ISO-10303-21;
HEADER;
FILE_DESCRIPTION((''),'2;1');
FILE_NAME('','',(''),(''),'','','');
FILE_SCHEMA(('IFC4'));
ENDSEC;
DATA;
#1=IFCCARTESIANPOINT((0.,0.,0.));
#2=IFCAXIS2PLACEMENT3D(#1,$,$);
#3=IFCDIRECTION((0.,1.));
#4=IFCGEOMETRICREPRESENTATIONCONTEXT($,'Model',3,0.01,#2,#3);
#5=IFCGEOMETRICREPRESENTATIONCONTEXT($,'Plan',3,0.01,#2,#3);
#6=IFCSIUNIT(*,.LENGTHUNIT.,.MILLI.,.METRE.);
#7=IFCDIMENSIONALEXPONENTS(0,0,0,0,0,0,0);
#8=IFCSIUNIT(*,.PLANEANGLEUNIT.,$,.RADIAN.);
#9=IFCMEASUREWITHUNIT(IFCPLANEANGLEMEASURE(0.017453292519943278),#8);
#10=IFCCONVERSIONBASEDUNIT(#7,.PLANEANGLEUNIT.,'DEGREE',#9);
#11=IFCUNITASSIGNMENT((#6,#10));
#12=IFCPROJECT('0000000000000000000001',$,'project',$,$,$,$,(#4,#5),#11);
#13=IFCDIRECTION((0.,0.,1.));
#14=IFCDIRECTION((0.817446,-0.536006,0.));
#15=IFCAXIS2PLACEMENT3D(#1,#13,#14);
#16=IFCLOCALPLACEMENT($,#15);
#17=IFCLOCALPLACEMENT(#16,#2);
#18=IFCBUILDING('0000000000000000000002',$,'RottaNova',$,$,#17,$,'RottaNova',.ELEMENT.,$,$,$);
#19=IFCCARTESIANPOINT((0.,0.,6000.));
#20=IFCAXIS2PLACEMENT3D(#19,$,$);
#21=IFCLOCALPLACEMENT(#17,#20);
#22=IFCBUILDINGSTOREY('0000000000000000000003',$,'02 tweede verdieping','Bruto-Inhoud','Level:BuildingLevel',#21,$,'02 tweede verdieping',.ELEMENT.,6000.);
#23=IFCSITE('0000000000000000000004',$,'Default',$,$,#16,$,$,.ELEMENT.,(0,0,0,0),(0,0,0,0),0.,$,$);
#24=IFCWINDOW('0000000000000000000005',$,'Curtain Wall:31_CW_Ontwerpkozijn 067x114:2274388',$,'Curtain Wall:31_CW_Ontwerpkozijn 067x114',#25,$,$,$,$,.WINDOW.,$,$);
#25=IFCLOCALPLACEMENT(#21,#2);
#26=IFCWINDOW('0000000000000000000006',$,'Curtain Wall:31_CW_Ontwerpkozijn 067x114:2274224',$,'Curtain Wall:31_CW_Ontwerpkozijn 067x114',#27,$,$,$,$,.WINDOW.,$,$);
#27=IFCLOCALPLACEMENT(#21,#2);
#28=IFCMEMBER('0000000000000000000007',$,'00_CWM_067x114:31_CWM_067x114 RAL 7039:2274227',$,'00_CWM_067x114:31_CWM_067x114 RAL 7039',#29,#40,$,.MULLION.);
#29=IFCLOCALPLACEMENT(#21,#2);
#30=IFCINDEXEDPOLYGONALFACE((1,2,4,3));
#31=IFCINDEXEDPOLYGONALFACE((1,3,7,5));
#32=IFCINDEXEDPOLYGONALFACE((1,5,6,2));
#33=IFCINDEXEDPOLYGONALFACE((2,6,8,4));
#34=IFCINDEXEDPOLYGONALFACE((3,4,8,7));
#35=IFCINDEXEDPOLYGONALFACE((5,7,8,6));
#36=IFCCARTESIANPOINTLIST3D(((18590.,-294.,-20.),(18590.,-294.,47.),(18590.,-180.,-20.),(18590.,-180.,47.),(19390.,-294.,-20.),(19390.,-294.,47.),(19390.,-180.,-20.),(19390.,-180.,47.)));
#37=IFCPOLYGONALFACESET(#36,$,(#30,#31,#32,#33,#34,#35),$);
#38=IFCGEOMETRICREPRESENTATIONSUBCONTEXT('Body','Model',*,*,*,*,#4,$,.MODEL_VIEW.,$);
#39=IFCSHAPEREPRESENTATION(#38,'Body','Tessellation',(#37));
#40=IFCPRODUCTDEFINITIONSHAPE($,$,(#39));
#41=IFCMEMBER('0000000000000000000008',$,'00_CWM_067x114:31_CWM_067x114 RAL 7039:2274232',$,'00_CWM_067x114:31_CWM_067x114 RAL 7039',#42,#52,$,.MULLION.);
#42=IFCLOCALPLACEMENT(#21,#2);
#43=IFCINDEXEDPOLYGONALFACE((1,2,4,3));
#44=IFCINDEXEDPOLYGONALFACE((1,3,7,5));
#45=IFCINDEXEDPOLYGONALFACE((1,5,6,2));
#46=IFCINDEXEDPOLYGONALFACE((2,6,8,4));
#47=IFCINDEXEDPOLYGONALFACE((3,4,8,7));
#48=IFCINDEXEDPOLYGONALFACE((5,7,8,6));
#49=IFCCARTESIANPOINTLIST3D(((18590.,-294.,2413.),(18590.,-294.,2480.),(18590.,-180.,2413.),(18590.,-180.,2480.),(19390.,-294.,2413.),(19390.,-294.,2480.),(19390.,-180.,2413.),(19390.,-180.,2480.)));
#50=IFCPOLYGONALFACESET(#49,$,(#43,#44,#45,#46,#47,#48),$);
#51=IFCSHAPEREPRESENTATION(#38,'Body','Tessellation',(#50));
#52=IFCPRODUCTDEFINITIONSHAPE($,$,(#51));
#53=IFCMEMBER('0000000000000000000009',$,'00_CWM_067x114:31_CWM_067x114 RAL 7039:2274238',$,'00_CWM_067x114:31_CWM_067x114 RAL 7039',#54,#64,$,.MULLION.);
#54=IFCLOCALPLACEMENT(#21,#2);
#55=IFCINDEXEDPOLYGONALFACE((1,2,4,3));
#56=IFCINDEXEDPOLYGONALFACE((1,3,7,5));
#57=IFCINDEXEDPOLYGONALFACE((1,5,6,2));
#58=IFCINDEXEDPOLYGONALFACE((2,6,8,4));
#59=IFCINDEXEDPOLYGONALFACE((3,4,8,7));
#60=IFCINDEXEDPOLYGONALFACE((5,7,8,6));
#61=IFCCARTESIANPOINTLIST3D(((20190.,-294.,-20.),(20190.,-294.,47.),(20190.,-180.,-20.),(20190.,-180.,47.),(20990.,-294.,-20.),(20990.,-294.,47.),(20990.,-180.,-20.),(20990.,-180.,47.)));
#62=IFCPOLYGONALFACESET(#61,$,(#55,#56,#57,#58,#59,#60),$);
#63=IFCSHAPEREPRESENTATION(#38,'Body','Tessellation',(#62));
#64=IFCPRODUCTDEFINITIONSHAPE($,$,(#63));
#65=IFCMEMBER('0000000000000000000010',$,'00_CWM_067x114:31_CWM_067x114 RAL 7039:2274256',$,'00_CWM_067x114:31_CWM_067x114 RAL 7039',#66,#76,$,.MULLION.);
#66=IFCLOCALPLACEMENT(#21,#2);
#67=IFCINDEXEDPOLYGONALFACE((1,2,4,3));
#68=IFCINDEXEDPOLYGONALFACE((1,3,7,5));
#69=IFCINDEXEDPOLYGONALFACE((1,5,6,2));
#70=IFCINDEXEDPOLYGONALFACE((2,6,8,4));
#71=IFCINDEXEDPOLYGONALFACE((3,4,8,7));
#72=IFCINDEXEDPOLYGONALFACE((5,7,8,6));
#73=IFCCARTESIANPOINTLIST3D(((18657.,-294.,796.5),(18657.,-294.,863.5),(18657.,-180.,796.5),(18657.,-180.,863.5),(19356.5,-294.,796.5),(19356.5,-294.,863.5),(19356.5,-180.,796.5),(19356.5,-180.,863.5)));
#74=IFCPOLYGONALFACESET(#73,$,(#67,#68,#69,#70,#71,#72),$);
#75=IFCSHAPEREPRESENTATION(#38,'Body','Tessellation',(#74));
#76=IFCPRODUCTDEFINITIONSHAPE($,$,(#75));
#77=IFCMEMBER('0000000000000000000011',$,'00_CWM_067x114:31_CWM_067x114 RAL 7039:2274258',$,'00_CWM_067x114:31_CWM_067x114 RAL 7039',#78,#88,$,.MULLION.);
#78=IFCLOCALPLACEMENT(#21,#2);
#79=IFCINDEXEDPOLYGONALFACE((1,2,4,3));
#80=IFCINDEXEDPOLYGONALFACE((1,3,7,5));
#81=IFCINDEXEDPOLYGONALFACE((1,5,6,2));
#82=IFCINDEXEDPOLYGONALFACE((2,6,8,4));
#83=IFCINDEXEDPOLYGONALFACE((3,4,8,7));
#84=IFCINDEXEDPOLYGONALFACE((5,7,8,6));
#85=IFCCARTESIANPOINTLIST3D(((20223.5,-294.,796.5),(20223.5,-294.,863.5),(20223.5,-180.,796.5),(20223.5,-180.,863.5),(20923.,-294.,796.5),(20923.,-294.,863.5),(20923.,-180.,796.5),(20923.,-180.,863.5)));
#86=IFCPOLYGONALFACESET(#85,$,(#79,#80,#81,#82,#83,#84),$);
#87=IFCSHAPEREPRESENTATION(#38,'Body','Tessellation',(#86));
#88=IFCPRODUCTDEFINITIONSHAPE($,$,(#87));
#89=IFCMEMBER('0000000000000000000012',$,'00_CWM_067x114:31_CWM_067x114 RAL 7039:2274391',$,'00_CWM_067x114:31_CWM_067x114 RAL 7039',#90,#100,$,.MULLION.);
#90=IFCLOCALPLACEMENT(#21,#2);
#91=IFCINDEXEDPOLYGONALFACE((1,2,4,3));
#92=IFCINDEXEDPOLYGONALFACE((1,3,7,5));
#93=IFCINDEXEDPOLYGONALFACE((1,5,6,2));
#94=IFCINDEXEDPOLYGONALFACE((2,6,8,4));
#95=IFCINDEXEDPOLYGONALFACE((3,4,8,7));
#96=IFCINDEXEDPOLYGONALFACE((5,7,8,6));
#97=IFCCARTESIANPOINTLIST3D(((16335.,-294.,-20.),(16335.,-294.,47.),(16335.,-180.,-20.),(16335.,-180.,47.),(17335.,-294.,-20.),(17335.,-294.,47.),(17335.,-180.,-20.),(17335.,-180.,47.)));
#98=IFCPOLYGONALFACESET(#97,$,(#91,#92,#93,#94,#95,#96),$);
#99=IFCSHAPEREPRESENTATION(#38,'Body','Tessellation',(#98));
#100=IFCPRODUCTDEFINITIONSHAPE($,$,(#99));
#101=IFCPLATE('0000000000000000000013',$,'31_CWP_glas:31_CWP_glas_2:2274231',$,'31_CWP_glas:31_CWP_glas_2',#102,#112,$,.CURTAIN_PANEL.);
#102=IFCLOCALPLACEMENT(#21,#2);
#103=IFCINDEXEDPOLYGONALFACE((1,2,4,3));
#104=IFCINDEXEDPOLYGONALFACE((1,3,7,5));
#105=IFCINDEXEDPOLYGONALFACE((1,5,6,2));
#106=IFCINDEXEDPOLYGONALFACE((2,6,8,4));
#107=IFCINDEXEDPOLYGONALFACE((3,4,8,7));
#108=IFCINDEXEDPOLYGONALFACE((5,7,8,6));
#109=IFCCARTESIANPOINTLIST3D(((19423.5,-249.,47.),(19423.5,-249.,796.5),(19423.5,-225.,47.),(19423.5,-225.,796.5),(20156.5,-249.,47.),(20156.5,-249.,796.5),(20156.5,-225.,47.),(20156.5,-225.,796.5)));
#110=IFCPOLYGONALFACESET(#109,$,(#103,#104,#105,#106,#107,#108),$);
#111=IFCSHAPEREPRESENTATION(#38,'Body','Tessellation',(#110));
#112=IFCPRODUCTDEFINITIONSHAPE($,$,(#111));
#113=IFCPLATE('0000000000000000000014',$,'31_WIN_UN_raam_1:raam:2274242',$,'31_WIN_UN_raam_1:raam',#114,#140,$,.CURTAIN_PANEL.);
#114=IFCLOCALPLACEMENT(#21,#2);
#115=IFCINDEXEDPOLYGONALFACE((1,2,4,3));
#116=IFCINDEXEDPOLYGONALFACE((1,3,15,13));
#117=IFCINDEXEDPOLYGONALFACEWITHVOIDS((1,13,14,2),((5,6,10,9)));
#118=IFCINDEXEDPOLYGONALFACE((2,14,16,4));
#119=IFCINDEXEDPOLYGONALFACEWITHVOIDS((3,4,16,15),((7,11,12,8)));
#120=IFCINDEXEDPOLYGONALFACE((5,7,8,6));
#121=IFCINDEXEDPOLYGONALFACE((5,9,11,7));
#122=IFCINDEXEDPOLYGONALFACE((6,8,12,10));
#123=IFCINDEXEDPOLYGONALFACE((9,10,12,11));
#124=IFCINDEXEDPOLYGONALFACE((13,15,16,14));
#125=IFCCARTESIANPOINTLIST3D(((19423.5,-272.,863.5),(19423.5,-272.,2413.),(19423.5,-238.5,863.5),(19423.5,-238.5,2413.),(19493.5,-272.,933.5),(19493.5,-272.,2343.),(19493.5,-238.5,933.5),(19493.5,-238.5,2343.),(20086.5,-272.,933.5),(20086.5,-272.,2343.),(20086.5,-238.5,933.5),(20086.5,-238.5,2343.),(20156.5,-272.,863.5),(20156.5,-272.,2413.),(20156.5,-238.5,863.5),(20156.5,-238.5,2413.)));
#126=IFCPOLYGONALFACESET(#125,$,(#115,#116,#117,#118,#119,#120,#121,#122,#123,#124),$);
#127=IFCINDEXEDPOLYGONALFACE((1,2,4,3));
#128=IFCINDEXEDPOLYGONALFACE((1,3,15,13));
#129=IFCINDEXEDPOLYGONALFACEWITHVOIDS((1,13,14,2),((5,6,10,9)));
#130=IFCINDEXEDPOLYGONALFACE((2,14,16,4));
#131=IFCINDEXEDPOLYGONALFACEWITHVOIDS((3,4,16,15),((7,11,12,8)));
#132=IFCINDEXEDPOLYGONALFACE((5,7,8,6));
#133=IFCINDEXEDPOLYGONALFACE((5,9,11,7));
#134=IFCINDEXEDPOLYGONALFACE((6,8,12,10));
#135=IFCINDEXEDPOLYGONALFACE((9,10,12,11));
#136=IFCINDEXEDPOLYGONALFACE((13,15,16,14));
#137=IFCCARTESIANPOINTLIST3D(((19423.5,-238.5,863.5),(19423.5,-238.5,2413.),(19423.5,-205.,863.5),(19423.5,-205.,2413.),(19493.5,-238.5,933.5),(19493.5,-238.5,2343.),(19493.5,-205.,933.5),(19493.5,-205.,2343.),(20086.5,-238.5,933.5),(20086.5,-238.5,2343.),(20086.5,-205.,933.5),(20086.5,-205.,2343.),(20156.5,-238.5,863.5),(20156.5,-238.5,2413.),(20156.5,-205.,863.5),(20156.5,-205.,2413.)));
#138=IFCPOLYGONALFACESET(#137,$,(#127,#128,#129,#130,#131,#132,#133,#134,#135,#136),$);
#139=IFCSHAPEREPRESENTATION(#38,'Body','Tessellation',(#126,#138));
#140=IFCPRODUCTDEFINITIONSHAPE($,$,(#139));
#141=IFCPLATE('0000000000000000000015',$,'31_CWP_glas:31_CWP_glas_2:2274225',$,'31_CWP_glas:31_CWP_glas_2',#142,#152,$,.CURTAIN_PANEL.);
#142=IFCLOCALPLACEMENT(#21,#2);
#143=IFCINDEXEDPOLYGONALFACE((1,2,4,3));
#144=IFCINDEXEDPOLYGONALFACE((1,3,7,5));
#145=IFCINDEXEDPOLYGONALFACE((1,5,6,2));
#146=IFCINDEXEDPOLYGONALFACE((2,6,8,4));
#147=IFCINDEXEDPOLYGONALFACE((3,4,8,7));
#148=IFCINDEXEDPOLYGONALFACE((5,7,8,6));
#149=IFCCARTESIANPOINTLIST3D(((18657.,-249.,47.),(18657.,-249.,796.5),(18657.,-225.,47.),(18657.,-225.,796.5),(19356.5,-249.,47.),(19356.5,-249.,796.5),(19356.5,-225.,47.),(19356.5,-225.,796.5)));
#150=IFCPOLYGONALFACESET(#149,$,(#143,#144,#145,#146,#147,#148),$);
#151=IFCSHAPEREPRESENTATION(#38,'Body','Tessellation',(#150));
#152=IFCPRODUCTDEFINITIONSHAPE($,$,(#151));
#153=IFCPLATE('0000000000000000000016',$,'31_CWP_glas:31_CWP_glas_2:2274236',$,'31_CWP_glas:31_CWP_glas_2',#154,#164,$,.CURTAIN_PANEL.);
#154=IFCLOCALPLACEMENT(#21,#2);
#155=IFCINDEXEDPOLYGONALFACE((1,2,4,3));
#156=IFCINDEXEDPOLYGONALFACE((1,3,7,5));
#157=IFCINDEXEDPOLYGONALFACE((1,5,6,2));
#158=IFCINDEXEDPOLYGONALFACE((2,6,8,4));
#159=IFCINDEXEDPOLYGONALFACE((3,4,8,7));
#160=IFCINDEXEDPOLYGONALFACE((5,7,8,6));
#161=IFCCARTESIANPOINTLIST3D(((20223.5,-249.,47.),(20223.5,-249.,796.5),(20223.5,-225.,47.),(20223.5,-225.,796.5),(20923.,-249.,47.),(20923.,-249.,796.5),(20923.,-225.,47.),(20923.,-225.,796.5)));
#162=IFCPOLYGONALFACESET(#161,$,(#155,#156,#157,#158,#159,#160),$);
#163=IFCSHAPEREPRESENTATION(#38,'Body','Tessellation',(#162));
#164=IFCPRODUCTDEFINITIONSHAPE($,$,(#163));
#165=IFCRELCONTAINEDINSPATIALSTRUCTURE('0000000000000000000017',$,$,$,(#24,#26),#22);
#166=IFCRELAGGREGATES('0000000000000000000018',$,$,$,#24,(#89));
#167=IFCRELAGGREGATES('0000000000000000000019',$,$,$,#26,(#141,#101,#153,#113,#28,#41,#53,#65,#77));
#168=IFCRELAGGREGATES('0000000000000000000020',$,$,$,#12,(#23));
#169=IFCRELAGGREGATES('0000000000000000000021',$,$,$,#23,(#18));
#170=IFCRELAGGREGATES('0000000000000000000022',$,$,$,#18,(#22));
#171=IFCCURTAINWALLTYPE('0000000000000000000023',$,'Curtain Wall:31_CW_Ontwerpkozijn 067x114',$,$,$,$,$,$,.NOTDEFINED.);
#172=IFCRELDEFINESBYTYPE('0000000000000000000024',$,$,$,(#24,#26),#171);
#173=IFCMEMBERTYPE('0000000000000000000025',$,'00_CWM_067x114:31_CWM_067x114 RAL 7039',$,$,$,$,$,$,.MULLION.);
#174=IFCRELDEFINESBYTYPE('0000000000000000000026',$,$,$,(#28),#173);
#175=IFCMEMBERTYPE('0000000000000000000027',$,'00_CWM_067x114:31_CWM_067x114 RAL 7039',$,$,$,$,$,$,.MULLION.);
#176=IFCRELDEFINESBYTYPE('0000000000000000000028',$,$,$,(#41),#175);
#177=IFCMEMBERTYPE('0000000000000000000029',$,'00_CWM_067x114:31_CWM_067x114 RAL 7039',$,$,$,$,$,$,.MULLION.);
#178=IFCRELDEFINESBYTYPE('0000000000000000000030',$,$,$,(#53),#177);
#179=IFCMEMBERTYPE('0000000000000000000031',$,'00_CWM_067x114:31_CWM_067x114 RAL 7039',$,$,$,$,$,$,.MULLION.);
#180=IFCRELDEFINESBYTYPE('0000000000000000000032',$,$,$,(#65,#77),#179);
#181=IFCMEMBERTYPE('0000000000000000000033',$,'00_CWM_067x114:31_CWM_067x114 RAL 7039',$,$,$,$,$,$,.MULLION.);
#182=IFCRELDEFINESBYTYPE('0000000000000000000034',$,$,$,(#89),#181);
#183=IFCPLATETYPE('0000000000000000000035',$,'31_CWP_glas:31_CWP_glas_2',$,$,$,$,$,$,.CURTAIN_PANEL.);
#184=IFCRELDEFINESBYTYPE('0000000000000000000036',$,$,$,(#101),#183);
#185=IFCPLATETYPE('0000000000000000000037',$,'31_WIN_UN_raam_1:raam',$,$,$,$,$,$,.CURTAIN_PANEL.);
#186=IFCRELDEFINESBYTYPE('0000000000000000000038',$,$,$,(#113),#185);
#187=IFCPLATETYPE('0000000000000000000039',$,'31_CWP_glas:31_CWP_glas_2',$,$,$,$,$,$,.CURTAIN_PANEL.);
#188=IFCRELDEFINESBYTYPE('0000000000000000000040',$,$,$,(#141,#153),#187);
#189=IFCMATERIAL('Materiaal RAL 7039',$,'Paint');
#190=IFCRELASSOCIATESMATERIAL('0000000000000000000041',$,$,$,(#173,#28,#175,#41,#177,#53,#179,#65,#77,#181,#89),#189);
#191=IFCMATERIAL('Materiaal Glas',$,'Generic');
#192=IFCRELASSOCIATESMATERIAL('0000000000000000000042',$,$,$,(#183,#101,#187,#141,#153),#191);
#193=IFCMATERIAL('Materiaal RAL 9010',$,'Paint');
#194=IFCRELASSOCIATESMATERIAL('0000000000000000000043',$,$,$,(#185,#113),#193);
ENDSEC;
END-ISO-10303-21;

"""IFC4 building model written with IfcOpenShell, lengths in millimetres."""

from ifc_helpers import new_model, entity, si_unit, converted_unit, direction, frame, origin, place, context, subcontext, project, spatial, indexed_curve, outline, extrude, source, transform, mapped, material, type_object, type_shapes, element, aggregate, save


model = new_model("IFC4")

# Units and contexts
model_context = context("Model", 3, precision=0.01, world=origin(), true_north=direction((0.0, 1.0)))
plan_context = context("Plan", 3, precision=0.01, world=origin(), true_north=direction((0.0, 1.0)))
body_context = subcontext(model_context, "Body", "Model", "MODEL_VIEW")
ifc_project = project(units=[si_unit("LENGTHUNIT", "METRE", prefix="MILLI"), converted_unit("PLANEANGLEUNIT", "DEGREE", entity("IfcPlaneAngleMeasure", 0.017453292519943278), si_unit("PLANEANGLEUNIT", "RADIAN"), dimensions=[0, 0, 0, 0, 0, 0, 0])], contexts=[model_context, plan_context])

# Site, building, storey
site_placement = place(None, frame((0.0, 0.0, 0.0), z_axis=(0.0, 0.0, 1.0), x_axis=(0.817446, -0.536006, 0.0)))
site = spatial("IfcSite", under=ifc_project, at=site_placement, Name="Default", CompositionType="ELEMENT", RefLatitude=(0, 0, 0, 0), RefLongitude=(0, 0, 0, 0), RefElevation=0.0)
building_placement = place(site_placement, origin())
building = spatial("IfcBuilding", under=site, at=building_placement, Name="RottaNova", LongName="RottaNova", CompositionType="ELEMENT")
storey_placement = place(building_placement, frame((0.0, 0.0, 6000.0)))
storey = spatial("IfcBuildingStorey", under=building, at=storey_placement, Name="02 tweede verdieping", Description="Bruto-Inhoud", ObjectType="Level:BuildingLevel", LongName="02 tweede verdieping", CompositionType="ELEMENT", Elevation=6000.0)

# Window
curtain_wall_type = type_object("IfcCurtainWallType", Name="Curtain Wall:31_CW_Ontwerpkozijn 067x114", PredefinedType="NOTDEFINED")
window_1_placement = place(storey_placement, frame((0.0, 0.0, -6000.0)))
window_1 = element("IfcWindow", 1, at=window_1_placement, inside=storey, type_object=curtain_wall_type, Name="Curtain Wall:31_CW_Ontwerpkozijn 067x114:2274388", ObjectType="Curtain Wall:31_CW_Ontwerpkozijn 067x114", PredefinedType="WINDOW")
ifc_material_1 = material(Name="Materiaal RAL 7039", Category="Paint")

# Window, members
window_2_placement = place(storey_placement, frame((0.0, 0.0, -6000.0)))
window_2 = element("IfcWindow", 2, at=window_2_placement, inside=storey, type_object=curtain_wall_type, Name="Curtain Wall:31_CW_Ontwerpkozijn 067x114:2274224", ObjectType="Curtain Wall:31_CW_Ontwerpkozijn 067x114", PredefinedType="WINDOW")
member_type_1 = type_object("IfcMemberType", Name="00_CWM_067x114:31_CWM_067x114 RAL 7039", PredefinedType="MULLION", material=ifc_material_1)
shared_shape_1 = source(origin(), body_context, "Body", "SweptSolid", [
    extrude(outline(indexed_curve([(-33.5, -57.0), (33.5, -57.0), (33.5, 57.0), (-33.5, 57.0), (-33.5, -57.0)], self_intersect=False)), frame((-33.5, 57.0, -800.0), z_axis=(0.0, 0.0, 1.0), x_axis=(-1.0, 0.0, 0.0)), (0.0, 0.0, 1.0), 800.0),
])
type_shapes(member_type_1, [shared_shape_1])
member_1_placement = place(window_2_placement, frame((18590.0, -180.0, 5980.0), z_axis=(-1.0, 0.0, 0.0), x_axis=(0.0, 0.0, -1.0)))
member_1 = element("IfcMember", 3, at=member_1_placement, type_object=member_type_1, material=ifc_material_1, Name="00_CWM_067x114:31_CWM_067x114 RAL 7039:2274227", ObjectType="00_CWM_067x114:31_CWM_067x114 RAL 7039", PredefinedType="MULLION", context=body_context, shape_type="MappedRepresentation", body=[
    mapped(shared_shape_1, transform((0.0, 0.0, 0.0), scale=1.0)),
])
member_type_2 = type_object("IfcMemberType", Name="00_CWM_067x114:31_CWM_067x114 RAL 7039", PredefinedType="MULLION", material=ifc_material_1)
shared_shape_2 = source(origin(), body_context, "Body", "SweptSolid", [
    extrude(outline(indexed_curve([(-33.5, -57.0), (33.5, -57.0), (33.5, 57.0), (-33.5, 57.0), (-33.5, -57.0)], self_intersect=False)), frame((-33.5, 57.0, -800.0), z_axis=(0.0, 0.0, 1.0), x_axis=(-1.0, 0.0, 0.0)), (0.0, 0.0, 1.0), 800.0),
])
type_shapes(member_type_2, [shared_shape_2])
member_2_placement = place(window_2_placement, frame((19390.0, -180.0, 8480.0), z_axis=(1.0, 0.0, 0.0), x_axis=(0.0, 0.0, 1.0)))
member_2 = element("IfcMember", 4, at=member_2_placement, type_object=member_type_2, material=ifc_material_1, Name="00_CWM_067x114:31_CWM_067x114 RAL 7039:2274232", ObjectType="00_CWM_067x114:31_CWM_067x114 RAL 7039", PredefinedType="MULLION", context=body_context, shape_type="MappedRepresentation", body=[
    mapped(shared_shape_2, transform((0.0, 0.0, 0.0), scale=1.0)),
])
member_type_3 = type_object("IfcMemberType", Name="00_CWM_067x114:31_CWM_067x114 RAL 7039", PredefinedType="MULLION", material=ifc_material_1)
shared_shape_3 = source(origin(), body_context, "Body", "SweptSolid", [
    extrude(outline(indexed_curve([(-33.5, -57.0), (33.5, -57.0), (33.5, 57.0), (-33.5, 57.0), (-33.5, -57.0)], self_intersect=False)), frame((-33.5, 57.0, -800.0), z_axis=(0.0, 0.0, 1.0), x_axis=(-1.0, 0.0, 0.0)), (0.0, 0.0, 1.0), 800.0),
])
type_shapes(member_type_3, [shared_shape_3])
member_3_placement = place(window_2_placement, frame((20190.0, -180.0, 5980.0), z_axis=(-1.0, 0.0, 0.0), x_axis=(0.0, 0.0, -1.0)))
member_3 = element("IfcMember", 5, at=member_3_placement, type_object=member_type_3, material=ifc_material_1, Name="00_CWM_067x114:31_CWM_067x114 RAL 7039:2274238", ObjectType="00_CWM_067x114:31_CWM_067x114 RAL 7039", PredefinedType="MULLION", context=body_context, shape_type="MappedRepresentation", body=[
    mapped(shared_shape_3, transform((0.0, 0.0, 0.0), scale=1.0)),
])
member_type_4 = type_object("IfcMemberType", Name="00_CWM_067x114:31_CWM_067x114 RAL 7039", PredefinedType="MULLION", material=ifc_material_1)
shared_shape_4 = source(origin(), body_context, "Body", "SweptSolid", [
    extrude(outline(indexed_curve([(-33.5, -57.0), (33.5, -57.0), (33.5, 57.0), (-33.5, 57.0), (-33.5, -57.0)], self_intersect=False)), frame((0.0, 57.0, -699.5), z_axis=(0.0, 0.0, 1.0), x_axis=(-1.0, 0.0, 0.0)), (0.0, 0.0, 1.0), 699.5),
])
type_shapes(member_type_4, [shared_shape_4])
member_4_placement = place(window_2_placement, frame((19356.5, -180.0, 6830.0), z_axis=(1.0, 0.0, 0.0), x_axis=(0.0, 0.0, 1.0)))
member_4 = element("IfcMember", 6, at=member_4_placement, type_object=member_type_4, material=ifc_material_1, Name="00_CWM_067x114:31_CWM_067x114 RAL 7039:2274256", ObjectType="00_CWM_067x114:31_CWM_067x114 RAL 7039", PredefinedType="MULLION", context=body_context, shape_type="MappedRepresentation", body=[
    mapped(shared_shape_4, transform((0.0, 0.0, 0.0), scale=1.0)),
])
member_5_placement = place(window_2_placement, frame((20923.0, -180.0, 6830.0), z_axis=(1.0, 0.0, 0.0), x_axis=(0.0, 0.0, 1.0)))
member_5 = element("IfcMember", 7, at=member_5_placement, type_object=member_type_4, material=ifc_material_1, Name="00_CWM_067x114:31_CWM_067x114 RAL 7039:2274258", ObjectType="00_CWM_067x114:31_CWM_067x114 RAL 7039", PredefinedType="MULLION", context=body_context, shape_type="MappedRepresentation", body=[
    mapped(shared_shape_4, transform((0.0, 0.0, 0.0), scale=1.0)),
])

# Member
member_type_5 = type_object("IfcMemberType", Name="00_CWM_067x114:31_CWM_067x114 RAL 7039", PredefinedType="MULLION", material=ifc_material_1)
shared_shape_5 = source(origin(), body_context, "Body", "SweptSolid", [
    extrude(outline(indexed_curve([(-33.5, -57.0), (33.5, -57.0), (33.5, 57.0), (-33.5, 57.0), (-33.5, -57.0)], self_intersect=False)), frame((-33.5, -57.0, -1000.0), z_axis=(0.0, 0.0, 1.0), x_axis=(-1.0, 0.0, 0.0)), (0.0, 0.0, 1.0), 1000.0),
])
type_shapes(member_type_5, [shared_shape_5])
member_6_placement = place(window_1_placement, frame((17335.0, -180.0, 5980.0), z_axis=(1.0, 0.0, 0.0), x_axis=(0.0, 0.0, -1.0)))
member_6 = element("IfcMember", 8, at=member_6_placement, type_object=member_type_5, material=ifc_material_1, Name="00_CWM_067x114:31_CWM_067x114 RAL 7039:2274391", ObjectType="00_CWM_067x114:31_CWM_067x114 RAL 7039", PredefinedType="MULLION", context=body_context, shape_type="MappedRepresentation", body=[
    mapped(shared_shape_5, transform((0.0, 0.0, 0.0), scale=1.0)),
])
aggregate(window_1, [member_6])

# Plates
ifc_material_2 = material(Name="Materiaal Glas", Category="Generic")
plate_type_1 = type_object("IfcPlateType", Name="31_CWP_glas:31_CWP_glas_2", PredefinedType="CURTAIN_PANEL", material=ifc_material_2)
shared_shape_6 = source(origin(), body_context, "Body", "SweptSolid", [
    extrude(outline(indexed_curve([(-12.0, -366.5), (12.0, -366.5), (12.0, 366.5), (-12.0, 366.5), (-12.0, -366.5)], self_intersect=False)), frame((0.0, -57.0, 0.0), z_axis=(0.0, 0.0, 1.0), x_axis=(0.0, 1.0, 0.0)), (0.0, 0.0, 1.0), 749.5),
])
type_shapes(plate_type_1, [shared_shape_6])
plate_1_placement = place(window_2_placement, frame((19790.0, -180.0, 6047.0)))
plate_1 = element("IfcPlate", 9, at=plate_1_placement, type_object=plate_type_1, material=ifc_material_2, Name="31_CWP_glas:31_CWP_glas_2:2274231", ObjectType="31_CWP_glas:31_CWP_glas_2", PredefinedType="CURTAIN_PANEL", context=body_context, shape_type="MappedRepresentation", body=[
    mapped(shared_shape_6, transform((0.0, 0.0, 0.0), scale=1.0)),
])
ifc_material_3 = material(Name="Materiaal RAL 9010", Category="Paint")
plate_type_2 = type_object("IfcPlateType", Name="31_WIN_UN_raam_1:raam", PredefinedType="CURTAIN_PANEL", material=ifc_material_3)
shared_shape_7 = source(origin(), body_context, "Body", "SweptSolid", [
    extrude(outline(indexed_curve([(-366.5, -774.8), (366.5, -774.8), (366.5, 774.8), (-366.5, 774.8), (-366.5, -774.8)], self_intersect=False), holes=[indexed_curve([(-296.5, 704.8), (296.5, 704.8), (296.5, -704.8), (-296.5, -704.8), (-296.5, 704.8)], self_intersect=False)]), frame((0.0, -92.0, 774.8), z_axis=(0.0, 1.0, 0.0), x_axis=(1.0, 0.0, 0.0)), (0.0, 0.0, 1.0), 33.5),
    extrude(outline(indexed_curve([(-366.5, -774.8), (366.5, -774.8), (366.5, 774.8), (-366.5, 774.8), (-366.5, -774.8)], self_intersect=False), holes=[indexed_curve([(-296.5, 704.7), (296.5, 704.7), (296.5, -704.8), (-296.5, -704.8), (-296.5, 704.7)], self_intersect=False)]), frame((0.0, -58.5, 774.8), z_axis=(0.0, 1.0, 0.0), x_axis=(1.0, 0.0, 0.0)), (0.0, 0.0, 1.0), 33.5),
])
type_shapes(plate_type_2, [shared_shape_7])
plate_2_placement = place(window_2_placement, frame((19790.0, -180.0, 6863.5)))
plate_2 = element("IfcPlate", 10, at=plate_2_placement, type_object=plate_type_2, material=ifc_material_3, Name="31_WIN_UN_raam_1:raam:2274242", ObjectType="31_WIN_UN_raam_1:raam", PredefinedType="CURTAIN_PANEL", context=body_context, shape_type="MappedRepresentation", body=[
    mapped(shared_shape_7, transform((0.0, 0.0, 0.0), scale=1.0)),
])
plate_type_3 = type_object("IfcPlateType", Name="31_CWP_glas:31_CWP_glas_2", PredefinedType="CURTAIN_PANEL", material=ifc_material_2)
shared_shape_8 = source(origin(), body_context, "Body", "SweptSolid", [
    extrude(outline(indexed_curve([(-12.0, -349.7), (12.0, -349.7), (12.0, 349.7), (-12.0, 349.7), (-12.0, -349.7)], self_intersect=False)), frame((0.0, -57.0, 0.0), z_axis=(0.0, 0.0, 1.0), x_axis=(0.0, 1.0, 0.0)), (0.0, 0.0, 1.0), 749.5),
])
type_shapes(plate_type_3, [shared_shape_8])
plate_3_placement = place(window_2_placement, frame((19006.8, -180.0, 6047.0)))
plate_3 = element("IfcPlate", 11, at=plate_3_placement, type_object=plate_type_3, material=ifc_material_2, Name="31_CWP_glas:31_CWP_glas_2:2274225", ObjectType="31_CWP_glas:31_CWP_glas_2", PredefinedType="CURTAIN_PANEL", context=body_context, shape_type="MappedRepresentation", body=[
    mapped(shared_shape_8, transform((0.0, 0.0, 0.0), scale=1.0)),
])
plate_4_placement = place(window_2_placement, frame((20573.3, -180.0, 6047.0)))
plate_4 = element("IfcPlate", 12, at=plate_4_placement, type_object=plate_type_3, material=ifc_material_2, Name="31_CWP_glas:31_CWP_glas_2:2274236", ObjectType="31_CWP_glas:31_CWP_glas_2", PredefinedType="CURTAIN_PANEL", context=body_context, shape_type="MappedRepresentation", body=[
    mapped(shared_shape_8, transform((0.0, 0.0, 0.0), scale=1.0)),
])
aggregate(window_2, [plate_3, plate_1, plate_4, plate_2, member_1, member_2, member_3, member_4, member_5])

save(model, "model.ifc")
